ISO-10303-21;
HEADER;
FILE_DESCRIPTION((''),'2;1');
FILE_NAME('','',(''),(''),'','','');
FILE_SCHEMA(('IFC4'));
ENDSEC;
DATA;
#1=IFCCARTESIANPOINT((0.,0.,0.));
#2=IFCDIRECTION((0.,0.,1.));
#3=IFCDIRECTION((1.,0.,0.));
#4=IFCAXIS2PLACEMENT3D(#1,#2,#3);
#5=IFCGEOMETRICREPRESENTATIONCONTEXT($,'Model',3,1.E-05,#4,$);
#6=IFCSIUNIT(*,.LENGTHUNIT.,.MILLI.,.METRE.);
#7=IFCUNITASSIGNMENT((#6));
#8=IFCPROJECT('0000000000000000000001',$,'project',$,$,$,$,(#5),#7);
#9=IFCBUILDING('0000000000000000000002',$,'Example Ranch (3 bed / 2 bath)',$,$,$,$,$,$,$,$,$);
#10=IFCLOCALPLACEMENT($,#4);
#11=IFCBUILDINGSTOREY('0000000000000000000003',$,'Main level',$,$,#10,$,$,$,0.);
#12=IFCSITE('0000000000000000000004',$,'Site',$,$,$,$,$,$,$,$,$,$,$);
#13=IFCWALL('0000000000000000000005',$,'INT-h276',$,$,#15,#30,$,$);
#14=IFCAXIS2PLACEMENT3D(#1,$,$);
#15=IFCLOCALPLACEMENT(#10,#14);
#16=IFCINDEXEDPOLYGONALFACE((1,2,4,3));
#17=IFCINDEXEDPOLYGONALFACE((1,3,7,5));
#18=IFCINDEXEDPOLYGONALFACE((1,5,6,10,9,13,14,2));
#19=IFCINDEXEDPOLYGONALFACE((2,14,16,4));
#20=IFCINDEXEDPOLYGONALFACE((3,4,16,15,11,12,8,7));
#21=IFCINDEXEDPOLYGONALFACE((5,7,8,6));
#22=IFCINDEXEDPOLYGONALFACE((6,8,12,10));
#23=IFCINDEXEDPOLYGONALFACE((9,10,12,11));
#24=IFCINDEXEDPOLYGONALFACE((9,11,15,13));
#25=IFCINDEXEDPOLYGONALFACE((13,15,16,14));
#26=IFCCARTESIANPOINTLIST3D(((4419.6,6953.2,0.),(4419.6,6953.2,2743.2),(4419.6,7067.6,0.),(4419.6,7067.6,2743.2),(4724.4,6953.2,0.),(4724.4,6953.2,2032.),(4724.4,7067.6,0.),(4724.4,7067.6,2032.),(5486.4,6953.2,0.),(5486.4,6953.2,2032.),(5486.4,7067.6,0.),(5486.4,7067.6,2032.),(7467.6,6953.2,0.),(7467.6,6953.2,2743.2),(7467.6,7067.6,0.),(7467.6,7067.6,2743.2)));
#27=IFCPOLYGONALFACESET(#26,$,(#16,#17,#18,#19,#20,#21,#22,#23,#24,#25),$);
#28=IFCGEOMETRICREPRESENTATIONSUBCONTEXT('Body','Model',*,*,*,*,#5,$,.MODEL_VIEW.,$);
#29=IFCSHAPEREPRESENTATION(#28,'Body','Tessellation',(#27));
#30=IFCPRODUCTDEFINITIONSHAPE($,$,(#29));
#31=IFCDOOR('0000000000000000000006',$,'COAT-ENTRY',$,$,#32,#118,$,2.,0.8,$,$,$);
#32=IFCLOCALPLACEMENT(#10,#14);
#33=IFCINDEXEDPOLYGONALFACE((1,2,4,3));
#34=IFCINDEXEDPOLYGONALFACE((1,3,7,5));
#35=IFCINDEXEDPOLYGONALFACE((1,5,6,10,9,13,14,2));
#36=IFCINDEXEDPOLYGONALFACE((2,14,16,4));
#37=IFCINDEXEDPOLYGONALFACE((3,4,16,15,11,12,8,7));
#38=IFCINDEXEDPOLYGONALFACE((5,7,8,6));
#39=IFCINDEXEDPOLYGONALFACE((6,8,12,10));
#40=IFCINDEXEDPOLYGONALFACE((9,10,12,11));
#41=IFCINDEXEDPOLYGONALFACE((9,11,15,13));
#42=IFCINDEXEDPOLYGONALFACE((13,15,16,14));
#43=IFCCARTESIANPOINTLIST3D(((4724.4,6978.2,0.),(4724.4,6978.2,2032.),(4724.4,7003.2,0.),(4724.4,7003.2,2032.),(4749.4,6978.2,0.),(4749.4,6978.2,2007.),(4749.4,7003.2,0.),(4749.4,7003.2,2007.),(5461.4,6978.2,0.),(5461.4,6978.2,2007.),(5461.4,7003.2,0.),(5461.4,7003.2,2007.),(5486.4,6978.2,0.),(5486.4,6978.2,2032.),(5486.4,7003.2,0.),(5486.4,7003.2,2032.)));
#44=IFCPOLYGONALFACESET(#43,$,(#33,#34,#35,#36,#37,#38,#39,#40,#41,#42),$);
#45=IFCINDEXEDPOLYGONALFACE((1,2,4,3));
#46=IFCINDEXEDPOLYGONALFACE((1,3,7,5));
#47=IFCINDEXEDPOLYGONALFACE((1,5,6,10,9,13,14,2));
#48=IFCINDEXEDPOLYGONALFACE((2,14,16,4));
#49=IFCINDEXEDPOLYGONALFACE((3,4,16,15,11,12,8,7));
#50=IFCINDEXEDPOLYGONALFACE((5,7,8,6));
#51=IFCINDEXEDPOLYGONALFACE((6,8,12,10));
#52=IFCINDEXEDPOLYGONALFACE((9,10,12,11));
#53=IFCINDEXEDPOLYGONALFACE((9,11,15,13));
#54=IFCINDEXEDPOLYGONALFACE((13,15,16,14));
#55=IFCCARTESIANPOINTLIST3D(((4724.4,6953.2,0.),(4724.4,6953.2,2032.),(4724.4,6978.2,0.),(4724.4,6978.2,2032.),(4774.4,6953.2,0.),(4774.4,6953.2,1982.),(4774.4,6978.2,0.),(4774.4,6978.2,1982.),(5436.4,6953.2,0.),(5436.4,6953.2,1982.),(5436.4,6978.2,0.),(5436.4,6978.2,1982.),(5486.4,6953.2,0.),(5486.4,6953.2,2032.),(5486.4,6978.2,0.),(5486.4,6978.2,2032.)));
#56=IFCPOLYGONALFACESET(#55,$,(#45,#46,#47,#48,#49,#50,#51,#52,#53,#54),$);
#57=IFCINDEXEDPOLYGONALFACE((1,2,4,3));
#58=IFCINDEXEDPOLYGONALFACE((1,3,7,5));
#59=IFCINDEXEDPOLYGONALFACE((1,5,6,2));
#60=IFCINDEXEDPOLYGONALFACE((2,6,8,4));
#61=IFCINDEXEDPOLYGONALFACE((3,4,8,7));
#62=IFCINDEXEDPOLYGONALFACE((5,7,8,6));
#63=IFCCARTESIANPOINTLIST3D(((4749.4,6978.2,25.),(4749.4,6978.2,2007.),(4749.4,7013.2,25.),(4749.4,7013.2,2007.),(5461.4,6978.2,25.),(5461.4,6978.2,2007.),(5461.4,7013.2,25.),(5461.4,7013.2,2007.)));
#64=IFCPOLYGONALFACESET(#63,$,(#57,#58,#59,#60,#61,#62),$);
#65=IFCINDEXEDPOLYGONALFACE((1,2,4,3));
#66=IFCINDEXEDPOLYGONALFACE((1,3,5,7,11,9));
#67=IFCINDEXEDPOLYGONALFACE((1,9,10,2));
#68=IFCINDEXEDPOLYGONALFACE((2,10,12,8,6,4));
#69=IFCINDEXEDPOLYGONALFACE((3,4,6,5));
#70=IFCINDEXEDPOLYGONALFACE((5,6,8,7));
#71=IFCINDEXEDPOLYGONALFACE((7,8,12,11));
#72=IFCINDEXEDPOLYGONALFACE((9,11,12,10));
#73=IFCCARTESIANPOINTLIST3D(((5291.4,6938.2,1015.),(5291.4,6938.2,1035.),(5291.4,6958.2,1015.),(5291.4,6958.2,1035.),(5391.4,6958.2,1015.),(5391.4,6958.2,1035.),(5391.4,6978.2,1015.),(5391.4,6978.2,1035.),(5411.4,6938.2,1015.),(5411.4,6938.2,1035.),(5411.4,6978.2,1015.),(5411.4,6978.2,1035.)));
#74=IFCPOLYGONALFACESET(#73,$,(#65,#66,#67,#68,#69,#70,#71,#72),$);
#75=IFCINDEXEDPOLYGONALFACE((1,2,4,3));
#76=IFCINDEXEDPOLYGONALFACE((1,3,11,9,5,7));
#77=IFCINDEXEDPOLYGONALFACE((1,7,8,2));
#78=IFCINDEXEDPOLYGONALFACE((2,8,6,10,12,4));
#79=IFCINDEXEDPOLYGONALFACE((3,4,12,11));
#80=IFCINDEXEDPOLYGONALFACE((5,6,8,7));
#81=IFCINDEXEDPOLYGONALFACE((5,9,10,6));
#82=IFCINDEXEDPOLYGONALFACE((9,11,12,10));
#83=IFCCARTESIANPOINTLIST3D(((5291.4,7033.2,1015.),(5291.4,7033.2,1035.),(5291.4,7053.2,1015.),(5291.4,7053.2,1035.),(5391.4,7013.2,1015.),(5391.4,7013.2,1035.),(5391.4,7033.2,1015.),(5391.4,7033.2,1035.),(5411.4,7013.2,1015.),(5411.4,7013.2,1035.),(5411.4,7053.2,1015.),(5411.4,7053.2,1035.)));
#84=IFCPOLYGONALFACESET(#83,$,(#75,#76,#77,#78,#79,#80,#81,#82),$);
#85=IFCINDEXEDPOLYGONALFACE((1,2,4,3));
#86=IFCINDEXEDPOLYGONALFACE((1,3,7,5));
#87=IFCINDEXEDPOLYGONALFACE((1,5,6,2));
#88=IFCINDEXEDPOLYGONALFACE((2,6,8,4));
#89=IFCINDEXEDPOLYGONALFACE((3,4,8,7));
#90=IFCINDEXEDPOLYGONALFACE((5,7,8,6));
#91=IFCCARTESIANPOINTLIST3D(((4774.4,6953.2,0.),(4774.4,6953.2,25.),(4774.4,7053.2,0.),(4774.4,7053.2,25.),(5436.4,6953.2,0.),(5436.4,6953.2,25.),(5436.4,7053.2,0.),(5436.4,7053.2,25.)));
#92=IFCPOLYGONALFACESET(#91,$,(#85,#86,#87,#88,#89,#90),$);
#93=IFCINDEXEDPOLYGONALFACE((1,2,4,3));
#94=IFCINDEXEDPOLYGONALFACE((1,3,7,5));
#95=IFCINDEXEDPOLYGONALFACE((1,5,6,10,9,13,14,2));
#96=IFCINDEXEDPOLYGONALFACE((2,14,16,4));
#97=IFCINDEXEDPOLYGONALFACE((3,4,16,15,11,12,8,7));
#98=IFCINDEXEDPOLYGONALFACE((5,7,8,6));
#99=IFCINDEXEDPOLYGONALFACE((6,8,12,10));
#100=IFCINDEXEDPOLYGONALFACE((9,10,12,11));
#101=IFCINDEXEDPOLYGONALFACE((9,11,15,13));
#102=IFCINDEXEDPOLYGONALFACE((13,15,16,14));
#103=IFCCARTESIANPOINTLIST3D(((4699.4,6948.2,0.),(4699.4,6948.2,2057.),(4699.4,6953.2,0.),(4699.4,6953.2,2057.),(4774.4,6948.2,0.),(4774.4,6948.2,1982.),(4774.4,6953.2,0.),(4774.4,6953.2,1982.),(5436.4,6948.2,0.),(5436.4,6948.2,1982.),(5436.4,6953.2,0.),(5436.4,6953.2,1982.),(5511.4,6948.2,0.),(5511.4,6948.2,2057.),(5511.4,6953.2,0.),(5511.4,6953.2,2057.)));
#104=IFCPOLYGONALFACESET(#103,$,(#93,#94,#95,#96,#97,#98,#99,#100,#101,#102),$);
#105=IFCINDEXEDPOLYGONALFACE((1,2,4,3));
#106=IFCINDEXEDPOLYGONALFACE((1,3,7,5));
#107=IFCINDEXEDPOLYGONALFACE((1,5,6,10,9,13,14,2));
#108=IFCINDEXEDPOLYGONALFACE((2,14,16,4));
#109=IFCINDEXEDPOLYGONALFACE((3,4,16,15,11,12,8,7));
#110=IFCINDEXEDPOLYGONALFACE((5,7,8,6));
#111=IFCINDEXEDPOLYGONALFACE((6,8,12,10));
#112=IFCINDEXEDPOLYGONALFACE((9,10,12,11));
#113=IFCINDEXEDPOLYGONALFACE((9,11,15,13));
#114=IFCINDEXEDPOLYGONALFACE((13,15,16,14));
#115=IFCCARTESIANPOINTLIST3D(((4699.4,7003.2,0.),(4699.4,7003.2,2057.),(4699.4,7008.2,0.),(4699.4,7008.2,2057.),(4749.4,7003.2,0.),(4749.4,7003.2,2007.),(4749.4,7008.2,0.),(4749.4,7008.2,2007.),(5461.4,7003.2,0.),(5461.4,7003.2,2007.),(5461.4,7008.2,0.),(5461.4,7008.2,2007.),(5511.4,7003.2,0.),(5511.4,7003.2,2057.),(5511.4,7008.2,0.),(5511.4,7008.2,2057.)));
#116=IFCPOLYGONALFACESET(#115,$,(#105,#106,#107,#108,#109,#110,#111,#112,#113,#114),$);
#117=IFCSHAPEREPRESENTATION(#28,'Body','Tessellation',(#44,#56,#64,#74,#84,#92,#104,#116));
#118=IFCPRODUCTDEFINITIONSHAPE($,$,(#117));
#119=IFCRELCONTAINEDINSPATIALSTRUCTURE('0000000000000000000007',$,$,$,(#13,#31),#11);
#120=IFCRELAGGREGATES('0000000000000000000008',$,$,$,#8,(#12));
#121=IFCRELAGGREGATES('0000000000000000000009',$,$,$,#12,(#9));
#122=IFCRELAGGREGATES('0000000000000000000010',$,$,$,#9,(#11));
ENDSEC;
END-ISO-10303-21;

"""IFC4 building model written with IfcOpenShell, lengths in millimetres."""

from ifc_helpers import new_model, si_unit, frame, origin_with_axes, place, context, subcontext, project, spatial, line, indexed_curve, outline, extrude, element, fill, save


model = new_model("IFC4")

# Units and contexts
model_context = context("Model", 3, precision=1e-05, world=origin_with_axes())
body_context = subcontext(model_context, "Body", "Model", "MODEL_VIEW")
ifc_project = project(units=[si_unit("LENGTHUNIT", "METRE", prefix="MILLI")], contexts=[model_context])

# Site, building, storey
site = spatial("IfcSite", under=ifc_project, Name="Site")
building = spatial("IfcBuilding", under=site, Name="Example Ranch (3 bed / 2 bath)")
storey_placement = place(None, origin_with_axes())
storey = spatial("IfcBuildingStorey", under=building, at=storey_placement, Name="Main level", Elevation=0.0)

# Wall, opening, door
wall_1_placement = place(storey_placement, frame((4419.6, 6953.2, 0.0), z_axis=(0.0, 0.0, 1.0), x_axis=(1.0, 0.0, 0.0)))
wall_1 = element("IfcWall", 1, at=wall_1_placement, inside=storey, Name="INT-h276", context=body_context, shape_type="SweptSolid", body=[
    extrude(outline(indexed_curve([(0.0, 0.0), (0.0, 114.3), (3048.0, 114.3), (3048.0, 0.0), (0.0, 0.0)], self_intersect=False)), origin_with_axes(), (0.0, 0.0, 1.0), 2743.2),
])
opening_1_placement = place(wall_1_placement, frame((304.8, 0.0, 0.0), z_axis=(0.0, 0.0, 1.0), x_axis=(1.0, 0.0, 0.0)))
opening_1 = element("IfcOpeningElement", 2, at=opening_1_placement, cuts=wall_1, context=body_context, shape_type="SweptSolid", body=[
    extrude(outline(indexed_curve([(0.0, 0.0), (0.0, 114.3), (762.0, 114.3), (762.0, 0.0), (0.0, 0.0)], self_intersect=False)), origin_with_axes(), (0.0, 0.0, 1.0), 2032.0),
])
door_1_placement = place(storey_placement, frame((4724.4, 6953.2, 0.0), z_axis=(0.0, 0.0, 1.0), x_axis=(1.0, 0.0, 0.0)))
door_1 = element("IfcDoor", 3, at=door_1_placement, inside=storey, Name="COAT-ENTRY", OverallHeight=2.0, OverallWidth=0.8, context=body_context, shape_type="SweptSolid", body=[
    extrude(outline(indexed_curve([(0.0, 0.0), (0.0, 2032.0), (762.0, 2032.0), (762.0, 0.0), (737.0, 0.0), (737.0, 2007.0), (25.0, 2007.0), (25.0, 0.0)], segments=[line(1, 2, 3, 4, 5, 6, 7, 8, 1)])), frame((0.0, 25.0, 0.0), z_axis=(0.0, -1.0, 0.0), x_axis=(1.0, 0.0, 0.0)), (0.0, 0.0, -1.0), 25.0),
    extrude(outline(indexed_curve([(0.0, 0.0), (0.0, 2032.0), (762.0, 2032.0), (762.0, 0.0), (712.0, 0.0), (712.0, 1982.0), (50.0, 1982.0), (50.0, 0.0)], segments=[line(1, 2, 3, 4, 5, 6, 7, 8, 1)])), frame((0.0, 0.0, 0.0), z_axis=(0.0, -1.0, 0.0), x_axis=(1.0, 0.0, 0.0)), (0.0, 0.0, -1.0), 25.0),
    extrude(outline(indexed_curve([(0.0, 0.0), (712.0, 0.0), (712.0, 35.0), (0.0, 35.0)], segments=[line(1, 2, 3, 4, 1)])), frame((25.0, 25.0, 25.0), z_axis=(0.0, 0.0, 1.0), x_axis=(1.0, 0.0, 0.0)), (0.0, 0.0, 1.0), 1982.0),
    extrude(outline(indexed_curve([(0.0, 0.0), (0.0, -40.0), (-120.0, -40.0), (-120.0, -20.0), (-20.0, -20.0), (-20.0, 0.0)], segments=[line(1, 2, 3, 4, 5, 6, 1)])), frame((687.0, 25.0, 1015.0), z_axis=(0.0, 0.0, 1.0), x_axis=(1.0, 0.0, 0.0)), (0.0, 0.0, 1.0), 20.0),
    extrude(outline(indexed_curve([(0.0, 0.0), (0.0, 40.0), (-120.0, 40.0), (-120.0, 20.0), (-20.0, 20.0), (-20.0, 0.0)], segments=[line(1, 2, 3, 4, 5, 6, 1)])), frame((687.0, 60.0, 1015.0), z_axis=(0.0, 0.0, 1.0), x_axis=(1.0, 0.0, 0.0)), (0.0, 0.0, 1.0), 20.0),
    extrude(outline(indexed_curve([(0.0, 0.0), (662.0, 0.0), (662.0, 100.0), (0.0, 100.0)], segments=[line(1, 2, 3, 4, 1)])), frame((50.0, 0.0, 0.0), z_axis=(0.0, 0.0, 1.0), x_axis=(1.0, 0.0, 0.0)), (0.0, 0.0, 1.0), 25.0),
    extrude(outline(indexed_curve([(0.0, 0.0), (0.0, 2057.0), (812.0, 2057.0), (812.0, 0.0), (737.0, 0.0), (737.0, 1982.0), (75.0, 1982.0), (75.0, 0.0)], segments=[line(1, 2, 3, 4, 5, 6, 7, 8, 1)])), frame((-25.0, -5.0, 0.0), z_axis=(0.0, -1.0, 0.0), x_axis=(1.0, 0.0, 0.0)), (0.0, 0.0, -1.0), 5.0),
    extrude(outline(indexed_curve([(0.0, 0.0), (0.0, 2057.0), (812.0, 2057.0), (812.0, 0.0), (762.0, 0.0), (762.0, 2007.0), (50.0, 2007.0), (50.0, 0.0)], segments=[line(1, 2, 3, 4, 5, 6, 7, 8, 1)])), frame((-25.0, 50.0, 0.0), z_axis=(0.0, -1.0, 0.0), x_axis=(1.0, 0.0, 0.0)), (0.0, 0.0, -1.0), 5.0),
])
fill(opening_1, door_1)

save(model, "model.ifc")
